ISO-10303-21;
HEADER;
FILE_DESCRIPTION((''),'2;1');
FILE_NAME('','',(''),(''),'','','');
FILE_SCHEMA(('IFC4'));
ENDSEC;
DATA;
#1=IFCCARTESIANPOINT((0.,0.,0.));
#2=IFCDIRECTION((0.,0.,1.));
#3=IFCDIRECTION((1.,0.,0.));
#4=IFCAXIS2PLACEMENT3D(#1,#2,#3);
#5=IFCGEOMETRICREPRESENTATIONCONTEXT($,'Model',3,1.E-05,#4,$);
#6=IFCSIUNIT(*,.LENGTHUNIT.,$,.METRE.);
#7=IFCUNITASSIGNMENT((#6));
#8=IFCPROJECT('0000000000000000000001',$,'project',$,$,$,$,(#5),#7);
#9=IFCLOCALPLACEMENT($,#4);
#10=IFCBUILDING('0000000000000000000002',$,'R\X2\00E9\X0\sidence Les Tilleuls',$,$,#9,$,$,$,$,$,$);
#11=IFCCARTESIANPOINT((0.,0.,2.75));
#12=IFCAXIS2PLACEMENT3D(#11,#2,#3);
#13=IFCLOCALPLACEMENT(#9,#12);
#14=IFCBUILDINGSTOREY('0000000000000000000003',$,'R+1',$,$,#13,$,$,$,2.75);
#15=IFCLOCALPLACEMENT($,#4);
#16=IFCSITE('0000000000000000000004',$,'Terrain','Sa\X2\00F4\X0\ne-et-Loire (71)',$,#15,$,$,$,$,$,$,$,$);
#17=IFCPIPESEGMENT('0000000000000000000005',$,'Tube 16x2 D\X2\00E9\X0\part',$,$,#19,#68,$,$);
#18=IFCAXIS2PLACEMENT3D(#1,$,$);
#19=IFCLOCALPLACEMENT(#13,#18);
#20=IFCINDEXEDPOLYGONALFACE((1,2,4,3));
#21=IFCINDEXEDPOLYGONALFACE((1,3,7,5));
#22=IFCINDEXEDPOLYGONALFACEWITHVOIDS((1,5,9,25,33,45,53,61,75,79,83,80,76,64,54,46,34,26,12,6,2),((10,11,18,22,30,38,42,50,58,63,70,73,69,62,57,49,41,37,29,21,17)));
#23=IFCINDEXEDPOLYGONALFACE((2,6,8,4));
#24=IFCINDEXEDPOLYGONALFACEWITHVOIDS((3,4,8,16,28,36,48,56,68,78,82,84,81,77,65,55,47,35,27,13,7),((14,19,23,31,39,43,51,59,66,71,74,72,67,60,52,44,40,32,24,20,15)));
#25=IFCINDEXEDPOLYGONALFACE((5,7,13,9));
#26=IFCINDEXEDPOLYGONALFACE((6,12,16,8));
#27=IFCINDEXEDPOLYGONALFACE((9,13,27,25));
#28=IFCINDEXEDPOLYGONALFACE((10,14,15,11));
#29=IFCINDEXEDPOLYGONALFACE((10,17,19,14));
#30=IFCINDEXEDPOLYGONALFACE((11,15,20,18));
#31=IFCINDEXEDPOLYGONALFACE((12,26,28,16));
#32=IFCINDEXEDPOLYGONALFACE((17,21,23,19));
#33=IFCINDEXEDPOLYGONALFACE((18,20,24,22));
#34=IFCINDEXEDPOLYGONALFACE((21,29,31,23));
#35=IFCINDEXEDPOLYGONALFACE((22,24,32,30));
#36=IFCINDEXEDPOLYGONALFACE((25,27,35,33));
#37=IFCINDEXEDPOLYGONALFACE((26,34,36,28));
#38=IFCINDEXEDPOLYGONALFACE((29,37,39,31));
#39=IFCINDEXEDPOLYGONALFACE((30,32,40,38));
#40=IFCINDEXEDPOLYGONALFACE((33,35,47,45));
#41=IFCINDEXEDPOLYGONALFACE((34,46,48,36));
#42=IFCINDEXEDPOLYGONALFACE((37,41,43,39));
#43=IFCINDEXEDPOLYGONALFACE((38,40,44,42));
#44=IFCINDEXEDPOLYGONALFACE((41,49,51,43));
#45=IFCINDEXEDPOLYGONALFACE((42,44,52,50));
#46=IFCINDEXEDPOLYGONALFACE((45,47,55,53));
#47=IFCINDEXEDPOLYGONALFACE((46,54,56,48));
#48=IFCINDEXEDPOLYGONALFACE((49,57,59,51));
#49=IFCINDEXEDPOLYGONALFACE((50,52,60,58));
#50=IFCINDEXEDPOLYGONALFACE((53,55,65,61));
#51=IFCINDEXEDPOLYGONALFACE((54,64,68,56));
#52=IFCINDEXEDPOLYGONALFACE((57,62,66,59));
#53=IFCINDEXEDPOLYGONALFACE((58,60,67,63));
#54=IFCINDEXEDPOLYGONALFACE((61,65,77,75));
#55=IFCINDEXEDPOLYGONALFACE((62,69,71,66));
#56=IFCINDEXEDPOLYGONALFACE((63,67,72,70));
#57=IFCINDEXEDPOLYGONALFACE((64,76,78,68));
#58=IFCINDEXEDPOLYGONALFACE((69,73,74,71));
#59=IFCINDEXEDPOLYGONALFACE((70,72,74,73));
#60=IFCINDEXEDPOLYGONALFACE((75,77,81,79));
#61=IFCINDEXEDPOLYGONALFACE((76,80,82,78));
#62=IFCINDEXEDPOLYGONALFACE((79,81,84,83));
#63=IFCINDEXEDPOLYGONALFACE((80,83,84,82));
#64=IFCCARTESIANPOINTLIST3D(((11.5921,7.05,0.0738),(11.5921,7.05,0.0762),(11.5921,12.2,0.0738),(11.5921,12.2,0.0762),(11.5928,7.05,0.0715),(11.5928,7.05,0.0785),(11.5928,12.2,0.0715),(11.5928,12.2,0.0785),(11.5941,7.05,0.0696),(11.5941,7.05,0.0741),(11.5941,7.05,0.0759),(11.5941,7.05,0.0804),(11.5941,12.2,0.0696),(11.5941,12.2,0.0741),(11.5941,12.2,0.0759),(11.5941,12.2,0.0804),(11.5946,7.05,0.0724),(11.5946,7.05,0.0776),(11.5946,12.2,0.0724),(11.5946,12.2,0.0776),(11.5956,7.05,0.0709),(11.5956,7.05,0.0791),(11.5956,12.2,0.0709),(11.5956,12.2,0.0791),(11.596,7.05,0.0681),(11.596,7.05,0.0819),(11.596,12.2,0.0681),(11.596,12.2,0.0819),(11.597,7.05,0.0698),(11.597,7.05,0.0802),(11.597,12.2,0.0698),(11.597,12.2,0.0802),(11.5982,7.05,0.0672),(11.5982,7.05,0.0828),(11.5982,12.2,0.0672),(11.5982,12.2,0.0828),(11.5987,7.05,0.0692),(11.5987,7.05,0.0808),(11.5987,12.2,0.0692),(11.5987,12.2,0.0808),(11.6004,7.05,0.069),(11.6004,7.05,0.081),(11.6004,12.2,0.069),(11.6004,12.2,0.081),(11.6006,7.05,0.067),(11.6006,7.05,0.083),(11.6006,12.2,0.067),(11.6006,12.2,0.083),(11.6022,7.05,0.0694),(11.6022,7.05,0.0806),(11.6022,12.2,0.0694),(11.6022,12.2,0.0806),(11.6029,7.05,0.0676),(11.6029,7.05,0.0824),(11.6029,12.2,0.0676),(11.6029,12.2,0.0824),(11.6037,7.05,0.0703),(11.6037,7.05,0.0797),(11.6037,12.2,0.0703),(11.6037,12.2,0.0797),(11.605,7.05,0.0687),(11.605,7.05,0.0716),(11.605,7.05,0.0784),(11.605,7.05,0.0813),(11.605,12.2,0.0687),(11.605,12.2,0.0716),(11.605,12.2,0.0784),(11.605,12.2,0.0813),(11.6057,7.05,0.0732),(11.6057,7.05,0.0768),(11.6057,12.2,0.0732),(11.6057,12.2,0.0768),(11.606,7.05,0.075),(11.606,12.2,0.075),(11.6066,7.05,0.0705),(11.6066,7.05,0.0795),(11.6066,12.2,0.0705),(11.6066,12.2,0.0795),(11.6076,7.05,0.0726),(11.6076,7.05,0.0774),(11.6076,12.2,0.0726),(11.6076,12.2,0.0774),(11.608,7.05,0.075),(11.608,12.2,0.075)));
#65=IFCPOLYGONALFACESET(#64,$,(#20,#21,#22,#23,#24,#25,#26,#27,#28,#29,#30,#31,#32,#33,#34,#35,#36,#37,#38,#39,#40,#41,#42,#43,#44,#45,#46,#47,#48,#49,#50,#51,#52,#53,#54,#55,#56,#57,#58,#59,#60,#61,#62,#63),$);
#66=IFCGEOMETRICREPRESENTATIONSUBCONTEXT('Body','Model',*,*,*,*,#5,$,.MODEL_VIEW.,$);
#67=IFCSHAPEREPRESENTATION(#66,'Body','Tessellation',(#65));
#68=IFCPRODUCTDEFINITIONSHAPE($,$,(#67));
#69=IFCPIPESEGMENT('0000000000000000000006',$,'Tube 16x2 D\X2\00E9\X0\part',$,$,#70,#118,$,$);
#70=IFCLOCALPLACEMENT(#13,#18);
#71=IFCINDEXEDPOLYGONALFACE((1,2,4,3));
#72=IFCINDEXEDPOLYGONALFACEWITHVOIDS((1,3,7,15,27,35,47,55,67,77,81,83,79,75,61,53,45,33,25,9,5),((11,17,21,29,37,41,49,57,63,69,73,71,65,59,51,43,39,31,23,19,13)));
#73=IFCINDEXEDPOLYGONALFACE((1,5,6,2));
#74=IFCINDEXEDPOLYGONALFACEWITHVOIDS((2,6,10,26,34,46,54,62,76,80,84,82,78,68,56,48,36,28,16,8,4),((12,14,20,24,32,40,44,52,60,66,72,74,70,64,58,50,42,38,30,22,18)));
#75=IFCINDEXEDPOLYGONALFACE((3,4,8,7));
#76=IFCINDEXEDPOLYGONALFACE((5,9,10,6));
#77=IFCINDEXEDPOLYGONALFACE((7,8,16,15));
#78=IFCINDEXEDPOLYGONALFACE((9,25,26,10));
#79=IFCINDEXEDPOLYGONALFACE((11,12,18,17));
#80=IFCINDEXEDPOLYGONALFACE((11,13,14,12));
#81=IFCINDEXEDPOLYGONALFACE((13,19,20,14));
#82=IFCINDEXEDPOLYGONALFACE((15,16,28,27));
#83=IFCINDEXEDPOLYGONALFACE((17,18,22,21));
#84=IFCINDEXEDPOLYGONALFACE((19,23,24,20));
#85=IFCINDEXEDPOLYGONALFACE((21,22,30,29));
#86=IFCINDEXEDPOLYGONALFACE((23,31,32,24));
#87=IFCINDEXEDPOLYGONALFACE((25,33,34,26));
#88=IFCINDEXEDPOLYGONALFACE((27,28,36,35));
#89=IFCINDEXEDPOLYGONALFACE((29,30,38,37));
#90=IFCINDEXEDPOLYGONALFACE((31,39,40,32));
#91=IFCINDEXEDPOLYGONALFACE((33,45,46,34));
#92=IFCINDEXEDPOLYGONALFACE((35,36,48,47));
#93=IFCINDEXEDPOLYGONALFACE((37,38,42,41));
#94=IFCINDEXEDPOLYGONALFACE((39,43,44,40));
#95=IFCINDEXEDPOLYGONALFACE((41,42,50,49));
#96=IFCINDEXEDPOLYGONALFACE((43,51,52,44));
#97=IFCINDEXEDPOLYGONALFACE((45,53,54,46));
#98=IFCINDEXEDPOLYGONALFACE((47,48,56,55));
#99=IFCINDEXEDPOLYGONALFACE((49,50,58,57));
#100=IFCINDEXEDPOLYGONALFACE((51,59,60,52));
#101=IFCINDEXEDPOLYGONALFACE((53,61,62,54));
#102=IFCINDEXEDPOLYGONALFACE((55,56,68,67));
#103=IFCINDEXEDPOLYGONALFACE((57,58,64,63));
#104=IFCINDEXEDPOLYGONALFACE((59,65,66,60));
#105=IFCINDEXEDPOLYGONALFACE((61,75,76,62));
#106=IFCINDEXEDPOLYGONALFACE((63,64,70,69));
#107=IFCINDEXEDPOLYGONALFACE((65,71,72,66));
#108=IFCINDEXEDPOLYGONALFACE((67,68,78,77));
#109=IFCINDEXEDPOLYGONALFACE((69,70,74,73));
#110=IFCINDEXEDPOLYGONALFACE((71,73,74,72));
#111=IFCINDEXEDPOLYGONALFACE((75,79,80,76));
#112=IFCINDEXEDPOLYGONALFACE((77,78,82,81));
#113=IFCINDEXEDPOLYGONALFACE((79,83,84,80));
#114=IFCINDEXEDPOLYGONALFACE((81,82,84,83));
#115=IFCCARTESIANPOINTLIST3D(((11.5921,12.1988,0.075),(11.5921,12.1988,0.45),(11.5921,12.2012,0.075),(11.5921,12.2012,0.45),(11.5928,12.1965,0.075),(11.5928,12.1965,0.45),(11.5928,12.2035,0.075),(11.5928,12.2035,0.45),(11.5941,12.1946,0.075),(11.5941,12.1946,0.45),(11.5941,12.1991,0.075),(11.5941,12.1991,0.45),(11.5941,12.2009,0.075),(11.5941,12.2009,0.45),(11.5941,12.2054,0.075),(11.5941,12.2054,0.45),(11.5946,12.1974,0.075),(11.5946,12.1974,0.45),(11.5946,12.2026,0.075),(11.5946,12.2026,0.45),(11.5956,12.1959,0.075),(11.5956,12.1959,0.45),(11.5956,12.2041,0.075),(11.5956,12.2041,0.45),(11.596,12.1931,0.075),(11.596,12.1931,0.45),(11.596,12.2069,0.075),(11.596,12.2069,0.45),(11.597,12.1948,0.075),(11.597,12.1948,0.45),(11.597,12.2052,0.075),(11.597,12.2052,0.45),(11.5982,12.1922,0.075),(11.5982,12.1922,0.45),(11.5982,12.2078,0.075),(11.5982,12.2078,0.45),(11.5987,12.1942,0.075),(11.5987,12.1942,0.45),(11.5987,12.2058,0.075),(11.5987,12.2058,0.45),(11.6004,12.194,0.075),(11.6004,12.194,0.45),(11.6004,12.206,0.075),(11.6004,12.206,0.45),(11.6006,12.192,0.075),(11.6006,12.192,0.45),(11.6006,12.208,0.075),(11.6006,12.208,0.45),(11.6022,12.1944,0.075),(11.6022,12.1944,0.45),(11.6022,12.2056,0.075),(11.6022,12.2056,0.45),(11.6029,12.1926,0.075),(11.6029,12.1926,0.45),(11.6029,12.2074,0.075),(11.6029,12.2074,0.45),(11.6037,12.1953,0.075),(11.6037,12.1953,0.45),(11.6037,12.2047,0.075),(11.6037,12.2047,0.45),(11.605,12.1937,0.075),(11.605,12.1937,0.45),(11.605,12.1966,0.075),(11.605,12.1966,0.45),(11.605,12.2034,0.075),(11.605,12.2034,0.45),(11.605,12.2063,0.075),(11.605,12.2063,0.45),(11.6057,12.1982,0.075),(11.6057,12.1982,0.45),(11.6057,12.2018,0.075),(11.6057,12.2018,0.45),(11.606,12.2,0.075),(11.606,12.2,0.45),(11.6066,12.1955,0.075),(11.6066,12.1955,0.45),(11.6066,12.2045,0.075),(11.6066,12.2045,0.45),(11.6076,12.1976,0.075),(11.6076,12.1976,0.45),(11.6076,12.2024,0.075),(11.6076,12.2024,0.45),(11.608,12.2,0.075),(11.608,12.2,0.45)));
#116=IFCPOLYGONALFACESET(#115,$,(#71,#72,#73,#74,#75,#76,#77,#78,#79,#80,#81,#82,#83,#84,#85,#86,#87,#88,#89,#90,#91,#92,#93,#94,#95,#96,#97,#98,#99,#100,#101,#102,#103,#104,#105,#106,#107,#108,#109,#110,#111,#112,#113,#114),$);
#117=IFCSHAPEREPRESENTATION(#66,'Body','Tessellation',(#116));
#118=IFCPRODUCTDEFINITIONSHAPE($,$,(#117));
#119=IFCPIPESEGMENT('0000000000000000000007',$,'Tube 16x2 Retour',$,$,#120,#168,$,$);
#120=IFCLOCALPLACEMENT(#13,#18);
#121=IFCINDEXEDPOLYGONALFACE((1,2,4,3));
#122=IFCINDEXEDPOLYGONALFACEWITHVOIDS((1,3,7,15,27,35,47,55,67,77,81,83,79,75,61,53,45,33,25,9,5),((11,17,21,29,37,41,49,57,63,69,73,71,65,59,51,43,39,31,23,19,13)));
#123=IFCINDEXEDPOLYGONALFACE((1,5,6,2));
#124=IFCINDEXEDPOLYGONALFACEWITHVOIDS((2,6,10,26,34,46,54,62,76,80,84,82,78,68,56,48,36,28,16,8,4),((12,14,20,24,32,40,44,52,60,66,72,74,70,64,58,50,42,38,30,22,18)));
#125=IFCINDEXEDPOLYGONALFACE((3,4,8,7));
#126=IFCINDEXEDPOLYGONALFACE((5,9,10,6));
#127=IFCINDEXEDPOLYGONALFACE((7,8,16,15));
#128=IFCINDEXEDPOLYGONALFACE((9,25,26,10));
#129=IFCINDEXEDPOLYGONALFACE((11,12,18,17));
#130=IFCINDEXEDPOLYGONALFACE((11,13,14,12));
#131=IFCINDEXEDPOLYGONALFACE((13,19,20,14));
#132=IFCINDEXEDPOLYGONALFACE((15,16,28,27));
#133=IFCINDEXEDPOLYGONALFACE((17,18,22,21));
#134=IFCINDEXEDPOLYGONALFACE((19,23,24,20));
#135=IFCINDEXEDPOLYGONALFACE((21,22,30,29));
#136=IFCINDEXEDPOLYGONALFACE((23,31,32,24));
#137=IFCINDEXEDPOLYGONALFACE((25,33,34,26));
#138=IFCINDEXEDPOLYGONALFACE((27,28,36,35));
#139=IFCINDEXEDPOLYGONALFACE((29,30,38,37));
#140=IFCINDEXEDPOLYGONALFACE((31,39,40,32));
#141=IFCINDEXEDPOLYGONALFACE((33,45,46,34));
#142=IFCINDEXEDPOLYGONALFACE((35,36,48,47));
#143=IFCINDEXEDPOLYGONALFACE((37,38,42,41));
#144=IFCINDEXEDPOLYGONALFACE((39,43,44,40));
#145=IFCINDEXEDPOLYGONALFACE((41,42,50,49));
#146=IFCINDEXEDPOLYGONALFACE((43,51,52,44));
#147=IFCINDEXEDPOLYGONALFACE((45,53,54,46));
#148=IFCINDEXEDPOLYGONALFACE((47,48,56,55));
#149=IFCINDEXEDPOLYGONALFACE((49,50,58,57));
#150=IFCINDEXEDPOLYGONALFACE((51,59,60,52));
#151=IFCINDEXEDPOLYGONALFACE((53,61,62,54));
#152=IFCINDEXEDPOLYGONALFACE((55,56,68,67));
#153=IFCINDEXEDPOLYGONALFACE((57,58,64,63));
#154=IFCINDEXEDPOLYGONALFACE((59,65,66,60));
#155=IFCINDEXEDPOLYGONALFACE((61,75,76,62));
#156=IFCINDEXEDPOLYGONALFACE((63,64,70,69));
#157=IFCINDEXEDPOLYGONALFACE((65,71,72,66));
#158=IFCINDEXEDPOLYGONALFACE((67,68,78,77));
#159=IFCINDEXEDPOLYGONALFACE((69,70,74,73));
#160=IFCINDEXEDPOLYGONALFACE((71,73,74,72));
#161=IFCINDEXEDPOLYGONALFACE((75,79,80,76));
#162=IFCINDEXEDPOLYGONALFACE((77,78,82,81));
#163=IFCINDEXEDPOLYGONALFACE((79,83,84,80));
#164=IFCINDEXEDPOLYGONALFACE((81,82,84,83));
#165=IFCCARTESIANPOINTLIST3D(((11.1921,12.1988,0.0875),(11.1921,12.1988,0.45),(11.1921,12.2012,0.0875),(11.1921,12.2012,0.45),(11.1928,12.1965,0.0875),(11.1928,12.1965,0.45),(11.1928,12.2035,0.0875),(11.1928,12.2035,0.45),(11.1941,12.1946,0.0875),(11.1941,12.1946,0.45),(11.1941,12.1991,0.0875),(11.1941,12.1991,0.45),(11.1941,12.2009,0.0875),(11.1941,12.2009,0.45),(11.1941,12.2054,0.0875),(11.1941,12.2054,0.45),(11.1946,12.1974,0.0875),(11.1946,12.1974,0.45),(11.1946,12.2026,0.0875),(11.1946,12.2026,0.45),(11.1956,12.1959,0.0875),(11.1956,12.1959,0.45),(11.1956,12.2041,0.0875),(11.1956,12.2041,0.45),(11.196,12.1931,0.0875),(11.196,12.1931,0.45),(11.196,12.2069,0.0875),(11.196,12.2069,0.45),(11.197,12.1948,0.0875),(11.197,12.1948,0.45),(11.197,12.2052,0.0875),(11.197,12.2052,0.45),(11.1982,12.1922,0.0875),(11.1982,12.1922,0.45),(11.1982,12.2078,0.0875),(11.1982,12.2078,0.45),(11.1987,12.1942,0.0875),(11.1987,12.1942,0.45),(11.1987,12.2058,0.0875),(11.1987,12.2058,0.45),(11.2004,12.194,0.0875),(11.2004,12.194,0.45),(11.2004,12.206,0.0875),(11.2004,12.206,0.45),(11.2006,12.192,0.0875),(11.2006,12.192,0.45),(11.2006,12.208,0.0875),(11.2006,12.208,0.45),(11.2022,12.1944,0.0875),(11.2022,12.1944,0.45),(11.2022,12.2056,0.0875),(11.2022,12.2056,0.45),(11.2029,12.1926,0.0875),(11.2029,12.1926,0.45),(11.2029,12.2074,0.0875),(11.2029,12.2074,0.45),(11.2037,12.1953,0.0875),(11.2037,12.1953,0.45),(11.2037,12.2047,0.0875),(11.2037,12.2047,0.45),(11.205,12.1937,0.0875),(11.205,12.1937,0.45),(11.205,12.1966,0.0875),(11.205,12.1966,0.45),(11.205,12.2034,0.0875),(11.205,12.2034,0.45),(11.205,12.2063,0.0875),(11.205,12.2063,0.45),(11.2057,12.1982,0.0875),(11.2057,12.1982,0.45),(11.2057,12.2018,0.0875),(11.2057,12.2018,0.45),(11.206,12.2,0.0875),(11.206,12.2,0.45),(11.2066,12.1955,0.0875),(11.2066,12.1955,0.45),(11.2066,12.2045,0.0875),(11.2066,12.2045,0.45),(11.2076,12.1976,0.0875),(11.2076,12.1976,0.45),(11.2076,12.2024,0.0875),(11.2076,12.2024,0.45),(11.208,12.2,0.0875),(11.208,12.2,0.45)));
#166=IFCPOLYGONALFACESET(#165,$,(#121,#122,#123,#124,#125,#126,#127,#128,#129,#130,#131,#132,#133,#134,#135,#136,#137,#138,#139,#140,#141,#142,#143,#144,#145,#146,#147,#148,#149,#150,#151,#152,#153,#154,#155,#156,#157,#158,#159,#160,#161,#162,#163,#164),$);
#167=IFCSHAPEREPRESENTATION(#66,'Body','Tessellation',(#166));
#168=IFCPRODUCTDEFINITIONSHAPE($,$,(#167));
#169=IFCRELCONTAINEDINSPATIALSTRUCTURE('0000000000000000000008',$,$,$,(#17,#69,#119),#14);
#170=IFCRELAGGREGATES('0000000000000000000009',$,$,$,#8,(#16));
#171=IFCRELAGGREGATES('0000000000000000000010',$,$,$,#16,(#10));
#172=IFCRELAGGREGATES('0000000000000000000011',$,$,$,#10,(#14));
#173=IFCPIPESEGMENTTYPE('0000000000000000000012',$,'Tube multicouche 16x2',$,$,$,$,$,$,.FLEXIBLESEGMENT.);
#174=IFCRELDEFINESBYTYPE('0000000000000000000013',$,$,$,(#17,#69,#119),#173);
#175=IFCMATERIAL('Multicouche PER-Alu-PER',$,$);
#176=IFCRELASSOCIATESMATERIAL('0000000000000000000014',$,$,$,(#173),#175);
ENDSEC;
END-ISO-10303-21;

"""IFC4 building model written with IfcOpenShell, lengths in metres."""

from ifc_helpers import new_model, si_unit, frame, origin_with_axes, place, context, subcontext, project, spatial, hollow_circle, extrude, material, type_object, element, save


model = new_model("IFC4")

# Units and contexts
model_context = context("Model", 3, precision=1e-05, world=origin_with_axes())
body_context = subcontext(model_context, "Body", "Model", "MODEL_VIEW")
ifc_project = project(units=[si_unit("LENGTHUNIT", "METRE")], contexts=[model_context])

# Site, building, storey
site_placement = place(None, origin_with_axes())
site = spatial("IfcSite", under=ifc_project, at=site_placement, Name="Terrain", Description="Saône-et-Loire (71)")
building_placement = place(None, origin_with_axes())
building = spatial("IfcBuilding", under=site, at=building_placement, Name="Résidence Les Tilleuls")
storey_placement = place(building_placement, frame((0.0, 0.0, 2.75), z_axis=(0.0, 0.0, 1.0), x_axis=(1.0, 0.0, 0.0)))
storey = spatial("IfcBuildingStorey", under=building, at=storey_placement, Name="R+1", Elevation=2.75)

# Pipe segments
ifc_material_1 = material(Name="Multicouche PER-Alu-PER")
pipe_segment_type_1 = type_object("IfcPipeSegmentType", Name="Tube multicouche 16x2", PredefinedType="FLEXIBLESEGMENT", material=ifc_material_1)
pipe_segment_1_placement = place(storey_placement, frame((11.6, 7.05, 0.075), z_axis=(0.0, 1.0, 0.0), x_axis=(1.0, 0.0, 0.0)))
element("IfcPipeSegment", 1, at=pipe_segment_1_placement, inside=storey, type_object=pipe_segment_type_1, Name="Tube 16x2 Départ", context=body_context, shape_type="SweptSolid", body=[
    extrude(hollow_circle(Radius=0.008, WallThickness=0.002), origin_with_axes(), (0.0, 0.0, 1.0), 5.15),
])
pipe_segment_2_placement = place(storey_placement, frame((11.6, 12.2, 0.075), z_axis=(0.0, 0.0, 1.0), x_axis=(1.0, 0.0, 0.0)))
element("IfcPipeSegment", 2, at=pipe_segment_2_placement, inside=storey, type_object=pipe_segment_type_1, Name="Tube 16x2 Départ", context=body_context, shape_type="SweptSolid", body=[
    extrude(hollow_circle(Radius=0.008, WallThickness=0.002), origin_with_axes(), (0.0, 0.0, 1.0), 0.375),
])
pipe_segment_3_placement = place(storey_placement, frame((11.2, 12.2, 0.0875), z_axis=(0.0, 0.0, 1.0), x_axis=(1.0, 0.0, 0.0)))
element("IfcPipeSegment", 3, at=pipe_segment_3_placement, inside=storey, type_object=pipe_segment_type_1, Name="Tube 16x2 Retour", context=body_context, shape_type="SweptSolid", body=[
    extrude(hollow_circle(Radius=0.008, WallThickness=0.002), origin_with_axes(), (0.0, 0.0, 1.0), 0.3625),
])

save(model, "model.ifc")
